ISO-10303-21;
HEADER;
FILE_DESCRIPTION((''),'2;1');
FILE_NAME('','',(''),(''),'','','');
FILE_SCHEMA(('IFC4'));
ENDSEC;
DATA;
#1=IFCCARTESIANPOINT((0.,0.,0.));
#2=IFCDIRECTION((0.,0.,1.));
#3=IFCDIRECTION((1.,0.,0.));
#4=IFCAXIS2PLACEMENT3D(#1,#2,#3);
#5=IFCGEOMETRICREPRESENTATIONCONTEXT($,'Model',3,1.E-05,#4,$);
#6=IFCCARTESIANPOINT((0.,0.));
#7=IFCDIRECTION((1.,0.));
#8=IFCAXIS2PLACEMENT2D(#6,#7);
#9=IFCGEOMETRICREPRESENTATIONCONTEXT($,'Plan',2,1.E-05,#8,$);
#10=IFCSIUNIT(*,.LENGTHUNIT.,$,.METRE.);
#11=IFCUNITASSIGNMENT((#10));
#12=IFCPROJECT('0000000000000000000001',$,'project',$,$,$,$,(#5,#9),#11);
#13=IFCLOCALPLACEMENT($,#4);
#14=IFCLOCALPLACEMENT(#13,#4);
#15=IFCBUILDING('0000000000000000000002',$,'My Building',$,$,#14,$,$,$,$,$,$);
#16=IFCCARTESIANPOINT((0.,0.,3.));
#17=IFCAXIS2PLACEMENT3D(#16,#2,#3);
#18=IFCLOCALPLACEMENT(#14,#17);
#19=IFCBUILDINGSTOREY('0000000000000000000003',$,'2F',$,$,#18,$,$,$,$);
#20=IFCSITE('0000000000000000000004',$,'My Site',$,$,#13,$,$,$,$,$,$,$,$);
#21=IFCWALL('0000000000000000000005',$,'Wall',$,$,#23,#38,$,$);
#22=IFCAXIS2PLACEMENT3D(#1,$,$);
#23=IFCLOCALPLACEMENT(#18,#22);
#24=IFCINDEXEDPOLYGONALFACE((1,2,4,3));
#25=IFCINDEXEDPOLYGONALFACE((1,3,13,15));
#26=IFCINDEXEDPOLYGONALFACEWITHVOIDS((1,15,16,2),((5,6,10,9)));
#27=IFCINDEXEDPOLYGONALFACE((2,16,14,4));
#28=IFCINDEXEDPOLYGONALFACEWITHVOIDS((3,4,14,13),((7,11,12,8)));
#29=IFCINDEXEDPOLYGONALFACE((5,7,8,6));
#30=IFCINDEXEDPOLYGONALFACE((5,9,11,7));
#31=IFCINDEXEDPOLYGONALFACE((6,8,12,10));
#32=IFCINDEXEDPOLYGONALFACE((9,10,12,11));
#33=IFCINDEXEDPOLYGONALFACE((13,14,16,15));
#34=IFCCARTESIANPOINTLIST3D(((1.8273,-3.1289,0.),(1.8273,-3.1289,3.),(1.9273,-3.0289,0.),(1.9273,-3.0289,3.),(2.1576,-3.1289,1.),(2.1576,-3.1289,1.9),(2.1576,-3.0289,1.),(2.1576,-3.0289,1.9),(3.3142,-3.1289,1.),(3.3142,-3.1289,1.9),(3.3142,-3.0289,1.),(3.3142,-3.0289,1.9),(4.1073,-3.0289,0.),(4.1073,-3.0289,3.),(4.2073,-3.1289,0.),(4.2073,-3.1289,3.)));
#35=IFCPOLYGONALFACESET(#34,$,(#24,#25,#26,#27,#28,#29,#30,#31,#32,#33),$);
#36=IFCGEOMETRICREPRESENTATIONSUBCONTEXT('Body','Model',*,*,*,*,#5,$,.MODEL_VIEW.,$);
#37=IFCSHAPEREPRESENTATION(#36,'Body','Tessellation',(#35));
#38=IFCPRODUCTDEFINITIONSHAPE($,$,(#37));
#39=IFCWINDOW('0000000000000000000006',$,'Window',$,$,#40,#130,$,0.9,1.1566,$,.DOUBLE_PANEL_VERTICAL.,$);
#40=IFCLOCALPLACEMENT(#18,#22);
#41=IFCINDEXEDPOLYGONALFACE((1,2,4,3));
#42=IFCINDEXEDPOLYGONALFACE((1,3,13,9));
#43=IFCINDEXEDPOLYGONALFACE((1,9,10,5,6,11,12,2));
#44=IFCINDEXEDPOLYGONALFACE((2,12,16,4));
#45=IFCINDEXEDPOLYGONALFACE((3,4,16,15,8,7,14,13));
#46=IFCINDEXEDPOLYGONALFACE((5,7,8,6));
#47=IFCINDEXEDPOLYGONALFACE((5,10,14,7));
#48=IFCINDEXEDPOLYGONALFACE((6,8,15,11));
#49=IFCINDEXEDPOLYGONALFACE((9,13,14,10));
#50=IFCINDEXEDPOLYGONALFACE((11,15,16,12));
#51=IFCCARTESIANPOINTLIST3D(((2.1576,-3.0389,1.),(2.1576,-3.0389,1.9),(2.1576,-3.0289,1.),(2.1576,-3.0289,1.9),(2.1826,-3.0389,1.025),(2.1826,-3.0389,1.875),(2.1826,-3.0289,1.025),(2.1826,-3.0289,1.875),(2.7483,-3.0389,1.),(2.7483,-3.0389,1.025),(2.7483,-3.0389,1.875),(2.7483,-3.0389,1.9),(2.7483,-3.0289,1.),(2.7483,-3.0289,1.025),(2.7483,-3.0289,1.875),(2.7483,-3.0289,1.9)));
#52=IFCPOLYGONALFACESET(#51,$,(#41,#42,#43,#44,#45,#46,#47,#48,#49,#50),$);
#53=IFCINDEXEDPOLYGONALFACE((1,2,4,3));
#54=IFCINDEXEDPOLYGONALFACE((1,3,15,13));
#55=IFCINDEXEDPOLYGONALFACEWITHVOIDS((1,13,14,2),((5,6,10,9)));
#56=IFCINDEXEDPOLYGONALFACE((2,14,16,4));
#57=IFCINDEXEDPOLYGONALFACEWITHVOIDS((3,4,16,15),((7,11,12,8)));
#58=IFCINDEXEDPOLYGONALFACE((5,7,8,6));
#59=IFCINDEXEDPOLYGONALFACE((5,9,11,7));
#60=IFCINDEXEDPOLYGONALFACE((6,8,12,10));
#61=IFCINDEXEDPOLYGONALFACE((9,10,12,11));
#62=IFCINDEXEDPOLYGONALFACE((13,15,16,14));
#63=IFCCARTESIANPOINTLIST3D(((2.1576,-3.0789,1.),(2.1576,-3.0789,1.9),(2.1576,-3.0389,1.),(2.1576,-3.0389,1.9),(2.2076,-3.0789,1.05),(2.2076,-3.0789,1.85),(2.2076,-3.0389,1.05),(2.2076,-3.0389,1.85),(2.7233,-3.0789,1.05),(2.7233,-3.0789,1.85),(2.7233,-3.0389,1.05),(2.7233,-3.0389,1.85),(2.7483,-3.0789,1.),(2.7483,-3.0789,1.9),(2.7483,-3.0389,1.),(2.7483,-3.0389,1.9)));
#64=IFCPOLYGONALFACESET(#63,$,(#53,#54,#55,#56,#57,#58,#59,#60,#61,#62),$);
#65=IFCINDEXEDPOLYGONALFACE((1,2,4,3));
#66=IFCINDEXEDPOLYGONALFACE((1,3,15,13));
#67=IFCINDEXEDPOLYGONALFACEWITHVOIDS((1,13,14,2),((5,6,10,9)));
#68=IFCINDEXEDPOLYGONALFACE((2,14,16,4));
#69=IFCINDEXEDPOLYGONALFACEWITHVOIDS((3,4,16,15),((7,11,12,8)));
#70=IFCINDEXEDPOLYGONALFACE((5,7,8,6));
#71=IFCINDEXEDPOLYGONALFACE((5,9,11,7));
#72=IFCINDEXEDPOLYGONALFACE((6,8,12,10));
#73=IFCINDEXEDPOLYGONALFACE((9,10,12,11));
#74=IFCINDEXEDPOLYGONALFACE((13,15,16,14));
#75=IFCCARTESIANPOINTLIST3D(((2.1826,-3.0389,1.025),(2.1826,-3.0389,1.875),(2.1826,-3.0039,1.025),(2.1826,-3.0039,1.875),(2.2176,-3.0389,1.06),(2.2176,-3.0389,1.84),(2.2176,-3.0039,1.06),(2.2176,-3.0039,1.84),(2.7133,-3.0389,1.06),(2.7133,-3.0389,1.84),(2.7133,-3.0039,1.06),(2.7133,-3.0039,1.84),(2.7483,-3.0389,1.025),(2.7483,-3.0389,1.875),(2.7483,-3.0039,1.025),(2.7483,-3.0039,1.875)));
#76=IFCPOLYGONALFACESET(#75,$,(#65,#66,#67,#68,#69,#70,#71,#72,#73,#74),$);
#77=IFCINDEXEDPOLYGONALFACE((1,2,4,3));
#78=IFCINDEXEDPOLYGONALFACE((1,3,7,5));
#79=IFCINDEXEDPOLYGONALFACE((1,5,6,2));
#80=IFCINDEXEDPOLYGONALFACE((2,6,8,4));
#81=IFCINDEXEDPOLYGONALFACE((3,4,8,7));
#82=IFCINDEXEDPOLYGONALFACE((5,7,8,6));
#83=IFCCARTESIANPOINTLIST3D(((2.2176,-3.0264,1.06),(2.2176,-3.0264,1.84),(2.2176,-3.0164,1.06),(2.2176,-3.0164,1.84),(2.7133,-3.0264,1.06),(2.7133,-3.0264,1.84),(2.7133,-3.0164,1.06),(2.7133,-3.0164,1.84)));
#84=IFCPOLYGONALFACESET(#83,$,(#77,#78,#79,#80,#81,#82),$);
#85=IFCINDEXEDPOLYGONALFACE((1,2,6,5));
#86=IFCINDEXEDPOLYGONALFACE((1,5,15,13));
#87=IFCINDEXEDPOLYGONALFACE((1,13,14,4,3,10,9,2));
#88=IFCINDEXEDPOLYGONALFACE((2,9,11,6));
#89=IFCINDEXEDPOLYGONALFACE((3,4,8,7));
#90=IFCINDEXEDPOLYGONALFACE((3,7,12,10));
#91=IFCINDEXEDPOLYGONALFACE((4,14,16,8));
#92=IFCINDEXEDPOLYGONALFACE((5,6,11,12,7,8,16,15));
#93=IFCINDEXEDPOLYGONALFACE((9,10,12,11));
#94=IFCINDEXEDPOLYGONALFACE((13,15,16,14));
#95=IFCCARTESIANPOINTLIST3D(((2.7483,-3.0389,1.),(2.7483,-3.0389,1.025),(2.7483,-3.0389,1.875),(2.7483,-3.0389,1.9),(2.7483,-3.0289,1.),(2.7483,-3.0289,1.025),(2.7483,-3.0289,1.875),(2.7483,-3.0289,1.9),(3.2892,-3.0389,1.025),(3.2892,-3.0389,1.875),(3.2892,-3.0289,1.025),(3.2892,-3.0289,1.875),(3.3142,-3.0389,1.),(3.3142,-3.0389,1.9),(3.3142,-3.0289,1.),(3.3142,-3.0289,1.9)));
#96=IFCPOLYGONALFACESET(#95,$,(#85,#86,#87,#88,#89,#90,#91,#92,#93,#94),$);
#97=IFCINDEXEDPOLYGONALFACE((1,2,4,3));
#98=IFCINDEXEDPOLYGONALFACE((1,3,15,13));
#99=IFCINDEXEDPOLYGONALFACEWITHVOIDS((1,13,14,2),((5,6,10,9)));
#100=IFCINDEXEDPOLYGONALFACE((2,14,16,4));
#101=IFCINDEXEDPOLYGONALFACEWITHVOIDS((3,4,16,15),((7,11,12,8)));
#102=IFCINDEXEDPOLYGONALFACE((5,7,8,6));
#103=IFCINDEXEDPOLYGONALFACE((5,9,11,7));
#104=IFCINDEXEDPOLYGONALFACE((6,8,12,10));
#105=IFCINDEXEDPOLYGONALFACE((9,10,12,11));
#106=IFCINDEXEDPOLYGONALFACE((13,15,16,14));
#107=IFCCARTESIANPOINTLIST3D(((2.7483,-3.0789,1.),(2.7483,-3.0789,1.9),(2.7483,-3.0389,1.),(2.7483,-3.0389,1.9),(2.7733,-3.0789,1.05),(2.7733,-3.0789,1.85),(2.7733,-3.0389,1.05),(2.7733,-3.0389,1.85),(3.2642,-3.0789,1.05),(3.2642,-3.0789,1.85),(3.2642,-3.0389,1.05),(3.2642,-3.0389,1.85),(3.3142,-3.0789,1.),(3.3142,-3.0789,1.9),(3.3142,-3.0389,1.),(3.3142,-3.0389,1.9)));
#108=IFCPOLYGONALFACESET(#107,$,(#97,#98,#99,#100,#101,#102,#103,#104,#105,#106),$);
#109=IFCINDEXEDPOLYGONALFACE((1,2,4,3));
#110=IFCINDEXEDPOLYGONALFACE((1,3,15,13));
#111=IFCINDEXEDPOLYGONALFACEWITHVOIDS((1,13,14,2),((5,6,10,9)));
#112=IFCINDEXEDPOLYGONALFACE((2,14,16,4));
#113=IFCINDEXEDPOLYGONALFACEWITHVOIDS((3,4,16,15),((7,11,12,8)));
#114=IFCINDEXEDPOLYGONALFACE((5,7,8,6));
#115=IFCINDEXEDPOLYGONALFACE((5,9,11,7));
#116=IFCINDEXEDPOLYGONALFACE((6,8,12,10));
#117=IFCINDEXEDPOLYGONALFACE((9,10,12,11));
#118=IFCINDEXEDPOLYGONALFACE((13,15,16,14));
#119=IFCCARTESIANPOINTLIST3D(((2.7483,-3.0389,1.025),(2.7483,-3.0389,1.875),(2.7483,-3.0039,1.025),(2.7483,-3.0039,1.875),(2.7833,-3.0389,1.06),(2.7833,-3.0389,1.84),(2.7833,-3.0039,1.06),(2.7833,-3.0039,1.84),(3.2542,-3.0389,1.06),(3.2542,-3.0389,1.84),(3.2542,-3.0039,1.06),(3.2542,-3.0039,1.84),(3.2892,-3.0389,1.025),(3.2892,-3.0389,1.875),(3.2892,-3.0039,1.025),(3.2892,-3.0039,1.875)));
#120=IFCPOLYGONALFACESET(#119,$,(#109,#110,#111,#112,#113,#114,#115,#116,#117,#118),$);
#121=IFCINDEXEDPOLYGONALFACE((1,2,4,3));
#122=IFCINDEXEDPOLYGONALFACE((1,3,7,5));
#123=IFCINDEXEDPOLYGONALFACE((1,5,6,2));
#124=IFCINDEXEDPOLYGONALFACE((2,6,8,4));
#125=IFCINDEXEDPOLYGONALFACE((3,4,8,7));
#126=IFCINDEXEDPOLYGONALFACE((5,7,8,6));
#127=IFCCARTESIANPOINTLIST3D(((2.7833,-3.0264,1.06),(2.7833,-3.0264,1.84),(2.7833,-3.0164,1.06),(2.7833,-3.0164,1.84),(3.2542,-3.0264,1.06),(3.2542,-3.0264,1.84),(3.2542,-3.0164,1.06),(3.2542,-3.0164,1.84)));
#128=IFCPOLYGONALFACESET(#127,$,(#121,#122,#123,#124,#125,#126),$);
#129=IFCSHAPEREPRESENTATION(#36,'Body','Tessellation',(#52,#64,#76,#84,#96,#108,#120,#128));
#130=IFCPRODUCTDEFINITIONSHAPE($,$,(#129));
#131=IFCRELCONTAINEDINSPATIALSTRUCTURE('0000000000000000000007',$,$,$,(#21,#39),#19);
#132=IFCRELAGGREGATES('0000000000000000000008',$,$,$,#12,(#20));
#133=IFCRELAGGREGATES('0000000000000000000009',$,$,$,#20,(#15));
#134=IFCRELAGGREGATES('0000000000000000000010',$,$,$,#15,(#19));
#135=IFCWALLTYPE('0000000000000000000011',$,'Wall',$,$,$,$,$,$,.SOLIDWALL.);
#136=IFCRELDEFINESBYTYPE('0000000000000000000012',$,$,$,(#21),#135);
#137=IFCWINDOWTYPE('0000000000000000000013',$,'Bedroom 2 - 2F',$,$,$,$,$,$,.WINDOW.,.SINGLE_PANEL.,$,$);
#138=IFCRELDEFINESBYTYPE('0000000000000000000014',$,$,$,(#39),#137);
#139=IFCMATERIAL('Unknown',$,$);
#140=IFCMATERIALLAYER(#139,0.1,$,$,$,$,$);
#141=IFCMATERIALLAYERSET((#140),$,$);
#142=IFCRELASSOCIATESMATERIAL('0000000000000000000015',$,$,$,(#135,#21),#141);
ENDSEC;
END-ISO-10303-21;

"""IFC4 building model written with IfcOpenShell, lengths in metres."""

from ifc_helpers import new_model, entity, si_unit, frame, origin_with_axes, origin_2d_with_axis, place, context, subcontext, project, spatial, line, indexed_curve, outline, extrude, shape, source, transform, mapped, material, layer, layer_set, layer_usage, type_object, type_shapes, element, fill, save


model = new_model("IFC4")

# Units and contexts
model_context = context("Model", 3, precision=1e-05, world=origin_with_axes())
plan_context = context("Plan", 2, precision=1e-05, world=origin_2d_with_axis())
body_context_1 = subcontext(model_context, "Body", "Model", "MODEL_VIEW")
body_context_2 = subcontext(plan_context, "Body", "Plan", "PLAN_VIEW")
ifc_project = project(units=[si_unit("LENGTHUNIT", "METRE")], contexts=[model_context, plan_context])

# Site, building, storey
site_placement = place(None, origin_with_axes())
site = spatial("IfcSite", under=ifc_project, at=site_placement, Name="My Site")
building_placement = place(site_placement, origin_with_axes())
building = spatial("IfcBuilding", under=site, at=building_placement, Name="My Building")
storey_placement = place(building_placement, frame((0.0, 0.0, 3.0), z_axis=(0.0, 0.0, 1.0), x_axis=(1.0, 0.0, 0.0)))
storey = spatial("IfcBuildingStorey", under=building, at=storey_placement, Name="2F")

# Shared definitions
ifc_material = material(Name="Unknown")

# Shared definitions
ifc_layer_1 = layer(ifc_material, 0.1)
ifc_layer_set_1 = layer_set([ifc_layer_1])
wall_type = type_object("IfcWallType", Name="Wall", PredefinedType="SOLIDWALL", material=ifc_layer_set_1)

# Wall, opening, window
ifc_layer_usage_1 = layer_usage(ifc_layer_set_1, "AXIS2", "POSITIVE", 0.0)
wall_1_placement = place(storey_placement, frame((1.8273, -3.1289, 0.0), z_axis=(0.0, 0.0, 1.0), x_axis=(1.0, 0.0, 0.0)))
wall_1 = element("IfcWall", 1, at=wall_1_placement, inside=storey, type_object=wall_type, material=ifc_layer_usage_1, Name="Wall", context=body_context_1, shape_type="SweptSolid", body=[
    extrude(outline(indexed_curve([(0.0, 0.0), (0.1, 0.1), (2.28, 0.1), (2.38, 0.0)], segments=[line(1, 2, 3, 4, 1)])), origin_with_axes(), (0.0, 0.0, 1.0), 3.0),
])
shared_shape_1 = source(origin_with_axes(), body_context_1, "Body", "SweptSolid", [
    extrude(outline(indexed_curve([(0.0, 0.0), (1.1566, 0.0), (1.1566, 0.9), (0.0, 0.9)], segments=[line(1, 2, 3, 4, 1)])), frame((0.0, -0.6, 0.0), z_axis=(0.0, -1.0, 0.0), x_axis=(1.0, 0.0, 0.0)), (0.0, 0.0, -1.0), 1.2),
])
opening_1_placement = place(wall_1_placement, frame((0.3303, 0.0, 1.0), z_axis=(0.0, 0.0, 1.0), x_axis=(1.0, 0.0, 0.0)))
opening_1 = element("IfcOpeningElement", 2, at=opening_1_placement, cuts=wall_1, PredefinedType="OPENING", context=body_context_1, shape_type="MappedRepresentation", body=[
    mapped(shared_shape_1, transform((0.0, 0.0, 0.0), x_axis=(1.0, 0.0, 0.0), y_axis=(0.0, 1.0, 0.0), z_axis=(0.0, 0.0, 1.0), scale=1.0)),
])
window_type_1 = type_object("IfcWindowType", Name="Bedroom 2 - 2F", PartitioningType="SINGLE_PANEL", PredefinedType="WINDOW")
shared_shape_2 = source(origin_with_axes(), body_context_1, "Body", "SweptSolid", [
    extrude(outline(indexed_curve([(0.5908, 0.0), (0.0, 0.0), (0.0, 0.9), (0.5908, 0.9), (0.5908, 0.875), (0.025, 0.875), (0.025, 0.025), (0.5908, 0.025)], segments=[line(1, 2, 3, 4, 5, 6, 7, 8, 1)])), frame((0.0, 0.09, 0.0), z_axis=(0.0, -1.0, 0.0), x_axis=(1.0, 0.0, 0.0)), (0.0, 0.0, -1.0), 0.01),
    extrude(outline(indexed_curve([(0.0, 0.0), (0.5908, 0.0), (0.5908, 0.9), (0.0, 0.9)], segments=[line(1, 2, 3, 4, 1)]), holes=[indexed_curve([(0.05, 0.05), (0.5658, 0.05), (0.5658, 0.85), (0.05, 0.85)], segments=[line(1, 2, 3, 4, 1)])]), frame((0.0, 0.05, 0.0), z_axis=(0.0, -1.0, 0.0), x_axis=(1.0, 0.0, 0.0)), (0.0, 0.0, -1.0), 0.04),
    extrude(outline(indexed_curve([(0.0, 0.0), (0.5658, 0.0), (0.5658, 0.85), (0.0, 0.85)], segments=[line(1, 2, 3, 4, 1)]), holes=[indexed_curve([(0.035, 0.035), (0.5308, 0.035), (0.5308, 0.815), (0.035, 0.815)], segments=[line(1, 2, 3, 4, 1)])]), frame((0.025, 0.09, 0.025), z_axis=(0.0, -1.0, 0.0), x_axis=(1.0, 0.0, 0.0)), (0.0, 0.0, -1.0), 0.035),
    extrude(outline(indexed_curve([(0.035, 0.035), (0.5308, 0.035), (0.5308, 0.815), (0.035, 0.815)], segments=[line(1, 2, 3, 4, 1)])), frame((0.025, 0.1025, 0.025), z_axis=(0.0, -1.0, 0.0), x_axis=(1.0, 0.0, 0.0)), (0.0, 0.0, -1.0), 0.01),
    extrude(outline(indexed_curve([(0.0, 0.9), (0.5659, 0.9), (0.5659, 0.0), (0.0, 0.0), (0.0, 0.025), (0.5409, 0.025), (0.5409, 0.875), (0.0, 0.875)], segments=[line(1, 2, 3, 4, 5, 6, 7, 8, 1)])), frame((0.5908, 0.09, 0.0), z_axis=(0.0, -1.0, 0.0), x_axis=(1.0, 0.0, 0.0)), (0.0, 0.0, -1.0), 0.01),
    extrude(outline(indexed_curve([(0.0, 0.0), (0.5659, 0.0), (0.5659, 0.9), (0.0, 0.9)], segments=[line(1, 2, 3, 4, 1)]), holes=[indexed_curve([(0.025, 0.05), (0.5159, 0.05), (0.5159, 0.85), (0.025, 0.85)], segments=[line(1, 2, 3, 4, 1)])]), frame((0.5908, 0.05, 0.0), z_axis=(0.0, -1.0, 0.0), x_axis=(1.0, 0.0, 0.0)), (0.0, 0.0, -1.0), 0.04),
    extrude(outline(indexed_curve([(0.0, 0.0), (0.5409, 0.0), (0.5409, 0.85), (0.0, 0.85)], segments=[line(1, 2, 3, 4, 1)]), holes=[indexed_curve([(0.035, 0.035), (0.5059, 0.035), (0.5059, 0.815), (0.035, 0.815)], segments=[line(1, 2, 3, 4, 1)])]), frame((0.5908, 0.09, 0.025), z_axis=(0.0, -1.0, 0.0), x_axis=(1.0, 0.0, 0.0)), (0.0, 0.0, -1.0), 0.035),
    extrude(outline(indexed_curve([(0.035, 0.035), (0.5059, 0.035), (0.5059, 0.815), (0.035, 0.815)], segments=[line(1, 2, 3, 4, 1)])), frame((0.5908, 0.1025, 0.025), z_axis=(0.0, -1.0, 0.0), x_axis=(1.0, 0.0, 0.0)), (0.0, 0.0, -1.0), 0.01),
])
shared_shape_3 = source(origin_with_axes(), body_context_2, "Body", "Curve2D", [
    entity("IfcIndexedPolyCurve", entity("IfcCartesianPointList2D", [[0.05, 0.05], [0.5658, 0.05]])),
    entity("IfcIndexedPolyCurve", entity("IfcCartesianPointList2D", [[0.0, 0.1], [0.025, 0.1], [0.025, 0.09], [0.05, 0.09], [0.05, 0.05], [0.0, 0.05]]), [entity("IfcLineIndex", [1, 2, 3, 4, 5, 6, 1])]),
    entity("IfcIndexedPolyCurve", entity("IfcCartesianPointList2D", [[0.5908, 0.1], [0.5908, 0.1], [0.5908, 0.09], [0.5658, 0.09], [0.5658, 0.05], [0.5908, 0.05]])),
    entity("IfcIndexedPolyCurve", entity("IfcCartesianPointList2D", [[0.025, 0.09], [0.06, 0.09], [0.06, 0.125], [0.025, 0.125]]), [entity("IfcLineIndex", [1, 2, 3, 4, 1])]),
    entity("IfcIndexedPolyCurve", entity("IfcCartesianPointList2D", [[0.5908, 0.09], [0.5558, 0.09], [0.5558, 0.125], [0.5908, 0.125]]), [entity("IfcLineIndex", [1, 2, 3, 4, 1])]),
    entity("IfcIndexedPolyCurve", entity("IfcCartesianPointList2D", [[0.06, 0.09], [0.5558, 0.09]])),
    entity("IfcIndexedPolyCurve", entity("IfcCartesianPointList2D", [[0.06, 0.125], [0.5558, 0.125]])),
    entity("IfcIndexedPolyCurve", entity("IfcCartesianPointList2D", [[0.06, 0.1075], [0.5558, 0.1075]])),
    entity("IfcIndexedPolyCurve", entity("IfcCartesianPointList2D", [[0.6158, 0.05], [1.1066, 0.05]])),
    entity("IfcIndexedPolyCurve", entity("IfcCartesianPointList2D", [[0.5908, 0.1], [0.5908, 0.1], [0.5908, 0.09], [0.6158, 0.09], [0.6158, 0.05], [0.5908, 0.05]])),
    entity("IfcIndexedPolyCurve", entity("IfcCartesianPointList2D", [[1.1566, 0.1], [1.1316, 0.1], [1.1316, 0.09], [1.1066, 0.09], [1.1066, 0.05], [1.1566, 0.05]]), [entity("IfcLineIndex", [1, 2, 3, 4, 5, 6, 1])]),
    entity("IfcIndexedPolyCurve", entity("IfcCartesianPointList2D", [[0.5908, 0.09], [0.6258, 0.09], [0.6258, 0.125], [0.5908, 0.125]]), [entity("IfcLineIndex", [1, 2, 3, 4, 1])]),
    entity("IfcIndexedPolyCurve", entity("IfcCartesianPointList2D", [[1.1316, 0.09], [1.0966, 0.09], [1.0966, 0.125], [1.1316, 0.125]]), [entity("IfcLineIndex", [1, 2, 3, 4, 1])]),
    entity("IfcIndexedPolyCurve", entity("IfcCartesianPointList2D", [[0.6258, 0.09], [1.0966, 0.09]])),
    entity("IfcIndexedPolyCurve", entity("IfcCartesianPointList2D", [[0.6258, 0.125], [1.0966, 0.125]])),
    entity("IfcIndexedPolyCurve", entity("IfcCartesianPointList2D", [[0.6258, 0.1075], [1.0966, 0.1075]])),
])
type_shapes(window_type_1, [shared_shape_2, shared_shape_3])
window_1_placement = place(opening_1_placement, origin_with_axes())
window_1 = element("IfcWindow", 3, at=window_1_placement, inside=storey, type_object=window_type_1, Name="Window", OverallHeight=0.9, OverallWidth=1.1566, PartitioningType="DOUBLE_PANEL_VERTICAL", shapes=[
    shape(body_context_1, "Body", "MappedRepresentation", [mapped(shared_shape_2, transform((0.0, 0.0, 0.0), x_axis=(1.0, 0.0, 0.0), y_axis=(0.0, 1.0, 0.0), z_axis=(0.0, 0.0, 1.0), scale=1.0))]),
    shape(body_context_2, "Body", "MappedRepresentation", [mapped(shared_shape_3, transform((0.0, 0.0, 0.0), x_axis=(1.0, 0.0, 0.0), y_axis=(0.0, 1.0, 0.0), z_axis=(0.0, 0.0, 1.0), scale=1.0))]),
])
fill(opening_1, window_1)

save(model, "model.ifc")
